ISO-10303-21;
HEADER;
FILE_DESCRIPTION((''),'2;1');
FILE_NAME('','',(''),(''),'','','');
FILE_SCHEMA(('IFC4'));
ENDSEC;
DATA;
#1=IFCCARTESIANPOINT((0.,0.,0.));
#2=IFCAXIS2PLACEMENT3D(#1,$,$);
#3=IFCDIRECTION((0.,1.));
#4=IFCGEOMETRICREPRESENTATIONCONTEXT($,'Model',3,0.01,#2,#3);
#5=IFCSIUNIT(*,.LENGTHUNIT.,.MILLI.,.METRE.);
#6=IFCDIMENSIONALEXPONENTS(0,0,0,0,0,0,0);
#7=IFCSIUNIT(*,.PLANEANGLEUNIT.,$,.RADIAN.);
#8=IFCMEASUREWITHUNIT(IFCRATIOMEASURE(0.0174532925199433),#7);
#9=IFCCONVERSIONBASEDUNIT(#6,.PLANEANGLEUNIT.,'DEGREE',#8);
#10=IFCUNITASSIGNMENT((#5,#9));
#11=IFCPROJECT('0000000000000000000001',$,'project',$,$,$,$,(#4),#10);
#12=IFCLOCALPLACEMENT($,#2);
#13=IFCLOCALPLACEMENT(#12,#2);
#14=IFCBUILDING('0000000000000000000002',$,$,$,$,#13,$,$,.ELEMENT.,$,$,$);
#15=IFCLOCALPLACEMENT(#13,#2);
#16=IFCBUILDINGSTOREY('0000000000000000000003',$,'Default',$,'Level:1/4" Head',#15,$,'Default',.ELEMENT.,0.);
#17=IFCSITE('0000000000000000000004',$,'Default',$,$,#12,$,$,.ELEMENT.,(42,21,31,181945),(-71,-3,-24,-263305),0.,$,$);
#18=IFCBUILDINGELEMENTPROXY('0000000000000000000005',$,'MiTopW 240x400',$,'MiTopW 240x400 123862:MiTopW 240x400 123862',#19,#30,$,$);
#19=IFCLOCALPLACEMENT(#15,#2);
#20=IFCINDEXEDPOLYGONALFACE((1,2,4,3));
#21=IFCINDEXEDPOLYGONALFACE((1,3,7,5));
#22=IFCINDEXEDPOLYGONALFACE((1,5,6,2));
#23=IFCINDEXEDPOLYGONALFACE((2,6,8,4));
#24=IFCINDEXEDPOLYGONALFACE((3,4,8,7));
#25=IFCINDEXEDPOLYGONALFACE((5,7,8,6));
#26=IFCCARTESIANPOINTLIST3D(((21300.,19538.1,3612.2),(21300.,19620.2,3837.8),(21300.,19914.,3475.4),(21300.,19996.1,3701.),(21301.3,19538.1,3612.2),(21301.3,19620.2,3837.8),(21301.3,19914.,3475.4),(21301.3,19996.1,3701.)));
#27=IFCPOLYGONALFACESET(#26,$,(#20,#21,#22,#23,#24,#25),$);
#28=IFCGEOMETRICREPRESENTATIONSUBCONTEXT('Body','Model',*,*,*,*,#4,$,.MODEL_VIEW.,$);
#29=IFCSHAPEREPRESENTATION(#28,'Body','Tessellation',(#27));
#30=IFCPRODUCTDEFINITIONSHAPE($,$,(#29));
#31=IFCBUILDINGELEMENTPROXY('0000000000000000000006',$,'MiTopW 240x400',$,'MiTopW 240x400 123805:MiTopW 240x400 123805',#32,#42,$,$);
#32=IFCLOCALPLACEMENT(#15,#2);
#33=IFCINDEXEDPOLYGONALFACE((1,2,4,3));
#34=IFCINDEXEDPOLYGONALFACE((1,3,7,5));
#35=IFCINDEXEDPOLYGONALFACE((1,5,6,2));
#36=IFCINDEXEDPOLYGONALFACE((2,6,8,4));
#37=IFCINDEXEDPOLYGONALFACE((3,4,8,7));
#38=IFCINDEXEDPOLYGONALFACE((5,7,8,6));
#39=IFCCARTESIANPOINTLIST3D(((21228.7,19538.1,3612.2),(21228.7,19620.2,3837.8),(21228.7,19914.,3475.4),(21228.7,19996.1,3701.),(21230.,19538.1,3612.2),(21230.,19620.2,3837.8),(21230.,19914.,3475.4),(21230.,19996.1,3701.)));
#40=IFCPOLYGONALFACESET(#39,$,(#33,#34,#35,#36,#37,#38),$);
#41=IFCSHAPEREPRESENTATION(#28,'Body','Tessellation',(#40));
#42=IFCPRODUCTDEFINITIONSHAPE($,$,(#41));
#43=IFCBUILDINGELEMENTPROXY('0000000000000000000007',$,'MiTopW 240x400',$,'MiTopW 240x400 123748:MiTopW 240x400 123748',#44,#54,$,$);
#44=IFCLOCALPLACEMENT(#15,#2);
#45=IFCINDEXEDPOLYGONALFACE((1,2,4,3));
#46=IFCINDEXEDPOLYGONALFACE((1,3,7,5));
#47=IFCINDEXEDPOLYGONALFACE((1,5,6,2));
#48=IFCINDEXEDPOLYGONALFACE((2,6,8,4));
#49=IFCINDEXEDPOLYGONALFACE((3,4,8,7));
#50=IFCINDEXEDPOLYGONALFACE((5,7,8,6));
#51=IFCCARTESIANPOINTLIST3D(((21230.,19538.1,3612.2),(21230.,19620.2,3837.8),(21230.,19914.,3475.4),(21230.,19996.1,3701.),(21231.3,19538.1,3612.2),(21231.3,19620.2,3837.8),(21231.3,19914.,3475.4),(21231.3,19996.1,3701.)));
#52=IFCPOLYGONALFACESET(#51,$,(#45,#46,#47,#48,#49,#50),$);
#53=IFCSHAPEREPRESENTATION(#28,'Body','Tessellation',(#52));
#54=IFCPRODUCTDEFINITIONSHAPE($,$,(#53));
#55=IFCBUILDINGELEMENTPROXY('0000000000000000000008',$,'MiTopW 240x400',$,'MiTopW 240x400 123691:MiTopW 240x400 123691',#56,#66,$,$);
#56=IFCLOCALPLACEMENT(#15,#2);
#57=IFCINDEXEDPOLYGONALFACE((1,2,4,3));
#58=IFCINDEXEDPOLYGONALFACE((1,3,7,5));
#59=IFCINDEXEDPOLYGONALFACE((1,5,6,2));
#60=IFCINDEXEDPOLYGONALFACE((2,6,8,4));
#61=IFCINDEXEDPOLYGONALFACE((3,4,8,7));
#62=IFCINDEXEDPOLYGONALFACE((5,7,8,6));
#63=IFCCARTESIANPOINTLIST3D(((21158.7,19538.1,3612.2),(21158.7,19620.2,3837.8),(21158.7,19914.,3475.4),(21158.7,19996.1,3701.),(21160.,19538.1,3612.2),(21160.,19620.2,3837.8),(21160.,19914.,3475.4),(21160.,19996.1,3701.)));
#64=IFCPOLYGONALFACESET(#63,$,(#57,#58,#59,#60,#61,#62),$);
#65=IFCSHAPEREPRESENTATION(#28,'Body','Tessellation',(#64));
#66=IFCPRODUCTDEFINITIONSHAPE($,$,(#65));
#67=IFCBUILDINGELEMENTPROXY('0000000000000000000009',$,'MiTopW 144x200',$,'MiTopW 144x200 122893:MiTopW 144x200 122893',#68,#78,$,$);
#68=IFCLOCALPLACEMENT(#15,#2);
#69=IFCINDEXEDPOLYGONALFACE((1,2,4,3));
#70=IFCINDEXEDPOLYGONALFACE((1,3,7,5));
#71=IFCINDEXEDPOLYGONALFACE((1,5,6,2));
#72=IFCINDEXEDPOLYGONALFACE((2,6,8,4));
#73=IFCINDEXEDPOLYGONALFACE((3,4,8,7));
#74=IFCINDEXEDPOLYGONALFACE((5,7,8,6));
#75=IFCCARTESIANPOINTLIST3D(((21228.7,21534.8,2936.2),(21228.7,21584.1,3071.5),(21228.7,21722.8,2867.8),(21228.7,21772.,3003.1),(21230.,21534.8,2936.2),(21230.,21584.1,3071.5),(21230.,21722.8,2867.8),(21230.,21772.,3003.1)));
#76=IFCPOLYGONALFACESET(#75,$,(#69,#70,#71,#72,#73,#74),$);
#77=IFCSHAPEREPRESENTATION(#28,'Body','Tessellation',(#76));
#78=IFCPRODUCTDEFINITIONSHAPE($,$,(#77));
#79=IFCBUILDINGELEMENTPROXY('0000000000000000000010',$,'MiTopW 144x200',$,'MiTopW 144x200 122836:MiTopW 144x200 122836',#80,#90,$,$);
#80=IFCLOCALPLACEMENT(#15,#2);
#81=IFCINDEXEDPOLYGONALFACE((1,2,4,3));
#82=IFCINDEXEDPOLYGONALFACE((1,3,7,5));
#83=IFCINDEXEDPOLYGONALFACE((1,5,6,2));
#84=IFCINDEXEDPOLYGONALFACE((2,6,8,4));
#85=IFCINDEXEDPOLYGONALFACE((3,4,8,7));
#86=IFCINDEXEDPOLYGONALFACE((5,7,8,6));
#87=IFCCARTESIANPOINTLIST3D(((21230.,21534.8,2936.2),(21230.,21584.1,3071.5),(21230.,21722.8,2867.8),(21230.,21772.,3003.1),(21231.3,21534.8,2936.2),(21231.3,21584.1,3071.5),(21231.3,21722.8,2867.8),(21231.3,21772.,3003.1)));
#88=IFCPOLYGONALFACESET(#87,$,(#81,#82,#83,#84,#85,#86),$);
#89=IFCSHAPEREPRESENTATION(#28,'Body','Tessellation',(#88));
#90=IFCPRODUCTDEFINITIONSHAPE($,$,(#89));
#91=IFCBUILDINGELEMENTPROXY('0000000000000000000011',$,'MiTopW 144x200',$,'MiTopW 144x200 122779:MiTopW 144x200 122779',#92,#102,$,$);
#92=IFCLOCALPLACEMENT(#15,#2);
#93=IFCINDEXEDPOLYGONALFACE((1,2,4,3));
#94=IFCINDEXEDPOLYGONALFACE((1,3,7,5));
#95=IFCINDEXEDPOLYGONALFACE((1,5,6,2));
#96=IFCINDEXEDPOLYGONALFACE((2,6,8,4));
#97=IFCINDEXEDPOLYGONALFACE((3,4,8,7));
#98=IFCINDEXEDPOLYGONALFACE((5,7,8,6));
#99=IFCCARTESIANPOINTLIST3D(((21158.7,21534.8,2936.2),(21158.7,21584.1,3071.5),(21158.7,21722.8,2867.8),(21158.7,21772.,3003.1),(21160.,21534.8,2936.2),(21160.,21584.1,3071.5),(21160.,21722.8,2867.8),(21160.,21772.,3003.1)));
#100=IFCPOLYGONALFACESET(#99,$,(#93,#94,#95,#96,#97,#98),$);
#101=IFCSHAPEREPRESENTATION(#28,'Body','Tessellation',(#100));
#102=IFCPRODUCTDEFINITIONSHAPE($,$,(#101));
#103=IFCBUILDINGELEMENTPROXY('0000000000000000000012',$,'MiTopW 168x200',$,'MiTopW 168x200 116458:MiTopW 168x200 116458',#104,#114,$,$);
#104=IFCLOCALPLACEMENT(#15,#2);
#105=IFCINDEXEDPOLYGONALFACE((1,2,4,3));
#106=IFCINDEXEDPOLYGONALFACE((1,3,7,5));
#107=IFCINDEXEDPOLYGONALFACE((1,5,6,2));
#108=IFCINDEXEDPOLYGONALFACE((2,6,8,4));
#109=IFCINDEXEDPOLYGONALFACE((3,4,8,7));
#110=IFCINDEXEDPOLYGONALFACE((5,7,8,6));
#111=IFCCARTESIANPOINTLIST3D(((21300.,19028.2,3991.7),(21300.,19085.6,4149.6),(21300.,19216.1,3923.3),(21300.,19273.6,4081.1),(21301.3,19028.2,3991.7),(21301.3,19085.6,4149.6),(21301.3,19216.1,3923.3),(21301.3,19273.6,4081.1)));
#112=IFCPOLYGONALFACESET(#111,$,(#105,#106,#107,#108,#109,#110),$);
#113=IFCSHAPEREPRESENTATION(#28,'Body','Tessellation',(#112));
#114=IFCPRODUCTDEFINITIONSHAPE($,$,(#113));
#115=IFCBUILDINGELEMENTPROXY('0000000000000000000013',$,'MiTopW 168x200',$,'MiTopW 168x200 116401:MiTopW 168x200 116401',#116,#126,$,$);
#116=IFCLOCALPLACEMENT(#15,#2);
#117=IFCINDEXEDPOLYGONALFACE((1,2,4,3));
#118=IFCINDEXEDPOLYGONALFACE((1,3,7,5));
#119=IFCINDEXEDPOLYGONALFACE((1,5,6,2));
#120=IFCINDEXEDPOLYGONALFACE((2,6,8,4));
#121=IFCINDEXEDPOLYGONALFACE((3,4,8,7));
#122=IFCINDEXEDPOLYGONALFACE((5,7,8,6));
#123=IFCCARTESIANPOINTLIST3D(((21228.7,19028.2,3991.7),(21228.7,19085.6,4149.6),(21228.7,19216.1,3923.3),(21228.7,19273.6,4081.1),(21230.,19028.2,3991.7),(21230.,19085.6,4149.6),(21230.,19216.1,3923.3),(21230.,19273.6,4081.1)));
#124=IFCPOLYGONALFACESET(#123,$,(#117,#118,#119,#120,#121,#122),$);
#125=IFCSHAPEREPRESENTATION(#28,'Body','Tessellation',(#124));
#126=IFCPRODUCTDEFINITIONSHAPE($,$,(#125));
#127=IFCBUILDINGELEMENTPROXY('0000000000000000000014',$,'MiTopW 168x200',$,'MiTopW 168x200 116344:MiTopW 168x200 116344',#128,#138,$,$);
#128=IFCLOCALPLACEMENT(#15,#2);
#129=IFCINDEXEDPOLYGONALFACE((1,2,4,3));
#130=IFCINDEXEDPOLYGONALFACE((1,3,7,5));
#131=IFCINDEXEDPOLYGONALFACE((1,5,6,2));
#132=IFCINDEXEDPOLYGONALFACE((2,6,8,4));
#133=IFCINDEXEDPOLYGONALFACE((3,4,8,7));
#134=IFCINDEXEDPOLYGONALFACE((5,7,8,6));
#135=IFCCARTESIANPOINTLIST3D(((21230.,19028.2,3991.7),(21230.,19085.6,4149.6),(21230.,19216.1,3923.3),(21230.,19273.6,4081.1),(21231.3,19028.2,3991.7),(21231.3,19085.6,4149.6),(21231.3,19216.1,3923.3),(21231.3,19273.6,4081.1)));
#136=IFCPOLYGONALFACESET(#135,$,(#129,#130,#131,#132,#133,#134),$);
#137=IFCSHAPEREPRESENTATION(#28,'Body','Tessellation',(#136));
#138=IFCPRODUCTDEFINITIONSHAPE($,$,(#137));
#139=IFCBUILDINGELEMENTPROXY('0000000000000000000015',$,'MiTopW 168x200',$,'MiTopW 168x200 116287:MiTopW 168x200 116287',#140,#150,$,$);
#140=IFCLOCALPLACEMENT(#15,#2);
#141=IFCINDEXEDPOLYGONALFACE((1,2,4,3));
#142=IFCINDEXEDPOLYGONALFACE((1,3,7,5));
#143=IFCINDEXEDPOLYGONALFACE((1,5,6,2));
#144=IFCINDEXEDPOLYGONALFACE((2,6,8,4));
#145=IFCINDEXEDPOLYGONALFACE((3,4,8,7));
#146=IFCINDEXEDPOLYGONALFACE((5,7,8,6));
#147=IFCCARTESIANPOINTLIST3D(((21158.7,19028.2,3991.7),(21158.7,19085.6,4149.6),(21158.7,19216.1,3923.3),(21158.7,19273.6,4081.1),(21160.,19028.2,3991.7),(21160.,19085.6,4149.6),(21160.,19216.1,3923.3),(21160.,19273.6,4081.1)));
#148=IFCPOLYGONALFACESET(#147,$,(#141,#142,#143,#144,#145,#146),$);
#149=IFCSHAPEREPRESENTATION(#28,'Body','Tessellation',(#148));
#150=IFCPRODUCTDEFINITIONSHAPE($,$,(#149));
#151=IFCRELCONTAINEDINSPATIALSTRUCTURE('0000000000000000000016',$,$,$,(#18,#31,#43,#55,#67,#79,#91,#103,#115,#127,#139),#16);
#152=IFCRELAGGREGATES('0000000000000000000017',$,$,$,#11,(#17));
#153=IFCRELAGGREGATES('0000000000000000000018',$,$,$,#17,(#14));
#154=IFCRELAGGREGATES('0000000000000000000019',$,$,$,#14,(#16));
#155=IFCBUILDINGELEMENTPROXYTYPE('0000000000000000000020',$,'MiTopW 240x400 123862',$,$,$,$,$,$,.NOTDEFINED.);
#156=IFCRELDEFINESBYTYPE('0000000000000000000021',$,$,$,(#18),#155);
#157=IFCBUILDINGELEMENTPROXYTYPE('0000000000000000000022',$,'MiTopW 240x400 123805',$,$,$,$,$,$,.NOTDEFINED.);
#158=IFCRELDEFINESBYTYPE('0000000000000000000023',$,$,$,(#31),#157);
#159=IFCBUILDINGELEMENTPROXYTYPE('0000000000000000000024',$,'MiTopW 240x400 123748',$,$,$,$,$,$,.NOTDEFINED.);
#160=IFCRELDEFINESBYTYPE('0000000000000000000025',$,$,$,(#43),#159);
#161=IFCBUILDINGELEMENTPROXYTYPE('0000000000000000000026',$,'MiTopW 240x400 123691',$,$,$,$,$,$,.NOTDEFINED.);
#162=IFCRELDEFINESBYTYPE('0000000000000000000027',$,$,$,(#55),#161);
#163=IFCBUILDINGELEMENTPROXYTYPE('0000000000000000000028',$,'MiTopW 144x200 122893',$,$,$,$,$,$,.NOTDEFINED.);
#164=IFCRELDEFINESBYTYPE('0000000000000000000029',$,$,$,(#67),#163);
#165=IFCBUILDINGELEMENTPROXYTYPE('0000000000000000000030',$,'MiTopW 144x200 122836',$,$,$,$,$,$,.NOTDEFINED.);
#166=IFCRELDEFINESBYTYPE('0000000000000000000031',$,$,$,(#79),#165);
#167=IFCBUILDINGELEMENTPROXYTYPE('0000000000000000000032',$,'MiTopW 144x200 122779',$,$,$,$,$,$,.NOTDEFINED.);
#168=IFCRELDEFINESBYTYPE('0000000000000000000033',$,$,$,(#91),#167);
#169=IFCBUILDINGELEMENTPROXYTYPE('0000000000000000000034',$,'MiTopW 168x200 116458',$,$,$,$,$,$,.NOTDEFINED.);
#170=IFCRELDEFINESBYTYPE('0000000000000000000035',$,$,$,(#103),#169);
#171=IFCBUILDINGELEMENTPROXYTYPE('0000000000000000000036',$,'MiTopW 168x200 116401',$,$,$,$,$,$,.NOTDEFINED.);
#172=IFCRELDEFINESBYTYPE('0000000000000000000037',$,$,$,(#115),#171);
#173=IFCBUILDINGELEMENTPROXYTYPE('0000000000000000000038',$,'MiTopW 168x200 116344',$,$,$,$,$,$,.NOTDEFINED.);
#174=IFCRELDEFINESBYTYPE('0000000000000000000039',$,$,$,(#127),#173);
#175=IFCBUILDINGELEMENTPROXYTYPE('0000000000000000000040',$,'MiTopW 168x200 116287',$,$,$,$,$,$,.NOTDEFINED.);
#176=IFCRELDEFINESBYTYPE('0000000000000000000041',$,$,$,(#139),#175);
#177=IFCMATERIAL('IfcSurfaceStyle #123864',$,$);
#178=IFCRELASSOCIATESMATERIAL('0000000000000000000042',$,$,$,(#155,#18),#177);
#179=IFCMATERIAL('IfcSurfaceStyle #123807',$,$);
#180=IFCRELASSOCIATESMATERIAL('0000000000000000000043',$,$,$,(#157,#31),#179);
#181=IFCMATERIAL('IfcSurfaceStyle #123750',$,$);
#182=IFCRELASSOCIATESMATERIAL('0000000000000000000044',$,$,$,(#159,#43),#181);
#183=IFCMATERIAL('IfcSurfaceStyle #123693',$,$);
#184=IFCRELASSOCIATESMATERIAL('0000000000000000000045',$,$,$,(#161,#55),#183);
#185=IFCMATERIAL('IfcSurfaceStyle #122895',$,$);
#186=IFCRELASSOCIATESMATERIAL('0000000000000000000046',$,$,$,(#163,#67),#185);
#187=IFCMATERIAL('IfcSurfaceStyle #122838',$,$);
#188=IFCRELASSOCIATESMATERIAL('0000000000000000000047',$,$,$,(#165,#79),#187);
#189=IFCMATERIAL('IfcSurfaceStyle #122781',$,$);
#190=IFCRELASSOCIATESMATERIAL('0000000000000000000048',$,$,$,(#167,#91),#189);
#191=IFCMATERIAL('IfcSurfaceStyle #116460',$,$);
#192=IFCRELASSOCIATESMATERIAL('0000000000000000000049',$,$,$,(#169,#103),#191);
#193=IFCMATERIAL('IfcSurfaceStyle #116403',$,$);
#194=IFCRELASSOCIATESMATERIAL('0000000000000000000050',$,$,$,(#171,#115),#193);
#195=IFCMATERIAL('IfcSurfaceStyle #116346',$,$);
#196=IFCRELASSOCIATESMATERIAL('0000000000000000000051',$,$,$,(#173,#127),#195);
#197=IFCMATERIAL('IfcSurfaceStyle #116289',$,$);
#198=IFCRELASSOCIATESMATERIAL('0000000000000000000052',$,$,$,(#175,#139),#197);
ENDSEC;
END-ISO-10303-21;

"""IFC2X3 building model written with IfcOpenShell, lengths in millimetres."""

from ifc_helpers import new_model, entity, si_unit, converted_unit, direction, frame, origin, place, context, subcontext, project, spatial, polyline, outline, extrude, source, transform, mapped, material, type_object, type_shapes, element, save


model = new_model("IFC2X3")

# Units and contexts
model_context = context("Model", 3, precision=0.01, world=origin(), true_north=direction((0.0, 1.0)))
body_context = subcontext(model_context, "Body", "Model", "MODEL_VIEW")
ifc_project = project(units=[si_unit("LENGTHUNIT", "METRE", prefix="MILLI"), converted_unit("PLANEANGLEUNIT", "DEGREE", entity("IfcRatioMeasure", 0.0174532925199433), si_unit("PLANEANGLEUNIT", "RADIAN"), dimensions=[0, 0, 0, 0, 0, 0, 0])], contexts=[model_context])

# Site, building, storey
site_placement = place(None, origin())
site = spatial("IfcSite", under=ifc_project, at=site_placement, Name="Default", CompositionType="ELEMENT", RefLatitude=(42, 21, 31, 181945), RefLongitude=(-71, -3, -24, -263305), RefElevation=0.0)
building_placement = place(site_placement, origin())
building = spatial("IfcBuilding", under=site, at=building_placement, CompositionType="ELEMENT")
storey_placement = place(building_placement, origin())
storey = spatial("IfcBuildingStorey", under=building, at=storey_placement, Name="Default", ObjectType="Level:1/4\" Head", LongName="Default", CompositionType="ELEMENT", Elevation=0.0)

# Building element proxies
ifc_material_1 = material(Name="IfcSurfaceStyle #123864")
building_element_proxy_type_1 = type_object("IfcBuildingElementProxyType", Name="MiTopW 240x400 123862", PredefinedType="NOTDEFINED", material=ifc_material_1)
shared_shape_1 = source(origin(), body_context, "Body", "SweptSolid", [
    extrude(outline(polyline([(-200.0, -120.0), (200.0, -120.0), (200.0, 120.0), (-200.0, 120.0), (-200.0, -120.0)])), frame((200.0, 120.0, 0.0), z_axis=(0.0, 0.0, 1.0), x_axis=(-1.0, 0.0, 0.0)), (0.0, 0.0, 1.0), 1.3),
])
type_shapes(building_element_proxy_type_1, [shared_shape_1])
proxy_1_placement = place(building_placement, frame((21301.3, 19620.2, 3837.8), z_axis=(-1.0, 0.0, 0.0), x_axis=(0.0, 0.939693, -0.34202)))
element("IfcBuildingElementProxy", 1, at=proxy_1_placement, inside=storey, type_object=building_element_proxy_type_1, material=ifc_material_1, Name="MiTopW 240x400", ObjectType="MiTopW 240x400 123862:MiTopW 240x400 123862", context=body_context, shape_type="MappedRepresentation", body=[
    mapped(shared_shape_1, transform((0.0, 0.0, 0.0), scale=1.0)),
])
ifc_material_2 = material(Name="IfcSurfaceStyle #123807")
building_element_proxy_type_2 = type_object("IfcBuildingElementProxyType", Name="MiTopW 240x400 123805", PredefinedType="NOTDEFINED", material=ifc_material_2)
shared_shape_2 = source(origin(), body_context, "Body", "SweptSolid", [
    extrude(outline(polyline([(-200.0, -120.0), (200.0, -120.0), (200.0, 120.0), (-200.0, 120.0), (-200.0, -120.0)])), frame((200.0, 120.0, 0.0), z_axis=(0.0, 0.0, 1.0), x_axis=(-1.0, 0.0, 0.0)), (0.0, 0.0, 1.0), 1.3),
])
type_shapes(building_element_proxy_type_2, [shared_shape_2])
proxy_2_placement = place(building_placement, frame((21230.0, 19620.2, 3837.8), z_axis=(-1.0, 0.0, 0.0), x_axis=(0.0, 0.939693, -0.34202)))
element("IfcBuildingElementProxy", 2, at=proxy_2_placement, inside=storey, type_object=building_element_proxy_type_2, material=ifc_material_2, Name="MiTopW 240x400", ObjectType="MiTopW 240x400 123805:MiTopW 240x400 123805", context=body_context, shape_type="MappedRepresentation", body=[
    mapped(shared_shape_2, transform((0.0, 0.0, 0.0), scale=1.0)),
])
ifc_material_3 = material(Name="IfcSurfaceStyle #123750")
building_element_proxy_type_3 = type_object("IfcBuildingElementProxyType", Name="MiTopW 240x400 123748", PredefinedType="NOTDEFINED", material=ifc_material_3)
shared_shape_3 = source(origin(), body_context, "Body", "SweptSolid", [
    extrude(outline(polyline([(-200.0, -120.0), (200.0, -120.0), (200.0, 120.0), (-200.0, 120.0), (-200.0, -120.0)])), frame((200.0, 120.0, 0.0), z_axis=(0.0, 0.0, 1.0), x_axis=(-1.0, 0.0, 0.0)), (0.0, 0.0, 1.0), 1.3),
])
type_shapes(building_element_proxy_type_3, [shared_shape_3])
proxy_3_placement = place(building_placement, frame((21231.3, 19620.2, 3837.8), z_axis=(-1.0, 0.0, 0.0), x_axis=(0.0, 0.939693, -0.34202)))
element("IfcBuildingElementProxy", 3, at=proxy_3_placement, inside=storey, type_object=building_element_proxy_type_3, material=ifc_material_3, Name="MiTopW 240x400", ObjectType="MiTopW 240x400 123748:MiTopW 240x400 123748", context=body_context, shape_type="MappedRepresentation", body=[
    mapped(shared_shape_3, transform((0.0, 0.0, 0.0), scale=1.0)),
])
ifc_material_4 = material(Name="IfcSurfaceStyle #123693")
building_element_proxy_type_4 = type_object("IfcBuildingElementProxyType", Name="MiTopW 240x400 123691", PredefinedType="NOTDEFINED", material=ifc_material_4)
shared_shape_4 = source(origin(), body_context, "Body", "SweptSolid", [
    extrude(outline(polyline([(-200.0, -120.0), (200.0, -120.0), (200.0, 120.0), (-200.0, 120.0), (-200.0, -120.0)])), frame((200.0, 120.0, 0.0), z_axis=(0.0, 0.0, 1.0), x_axis=(-1.0, 0.0, 0.0)), (0.0, 0.0, 1.0), 1.3),
])
type_shapes(building_element_proxy_type_4, [shared_shape_4])
proxy_4_placement = place(building_placement, frame((21160.0, 19620.2, 3837.8), z_axis=(-1.0, 0.0, 0.0), x_axis=(0.0, 0.939693, -0.34202)))
element("IfcBuildingElementProxy", 4, at=proxy_4_placement, inside=storey, type_object=building_element_proxy_type_4, material=ifc_material_4, Name="MiTopW 240x400", ObjectType="MiTopW 240x400 123691:MiTopW 240x400 123691", context=body_context, shape_type="MappedRepresentation", body=[
    mapped(shared_shape_4, transform((0.0, 0.0, 0.0), scale=1.0)),
])
ifc_material_5 = material(Name="IfcSurfaceStyle #122895")
building_element_proxy_type_5 = type_object("IfcBuildingElementProxyType", Name="MiTopW 144x200 122893", PredefinedType="NOTDEFINED", material=ifc_material_5)
shared_shape_5 = source(origin(), body_context, "Body", "SweptSolid", [
    extrude(outline(polyline([(-100.0, -72.0), (100.0, -72.0), (100.0, 72.0), (-100.0, 72.0), (-100.0, -72.0)])), frame((100.0, 72.0, 0.0), z_axis=(0.0, 0.0, 1.0), x_axis=(-1.0, 0.0, 0.0)), (0.0, 0.0, 1.0), 1.3),
])
type_shapes(building_element_proxy_type_5, [shared_shape_5])
proxy_5_placement = place(building_placement, frame((21230.0, 21584.1, 3071.5), z_axis=(-1.0, 0.0, 0.0), x_axis=(0.0, 0.939693, -0.34202)))
element("IfcBuildingElementProxy", 5, at=proxy_5_placement, inside=storey, type_object=building_element_proxy_type_5, material=ifc_material_5, Name="MiTopW 144x200", ObjectType="MiTopW 144x200 122893:MiTopW 144x200 122893", context=body_context, shape_type="MappedRepresentation", body=[
    mapped(shared_shape_5, transform((0.0, 0.0, 0.0), scale=1.0)),
])
ifc_material_6 = material(Name="IfcSurfaceStyle #122838")
building_element_proxy_type_6 = type_object("IfcBuildingElementProxyType", Name="MiTopW 144x200 122836", PredefinedType="NOTDEFINED", material=ifc_material_6)
shared_shape_6 = source(origin(), body_context, "Body", "SweptSolid", [
    extrude(outline(polyline([(-100.0, -72.0), (100.0, -72.0), (100.0, 72.0), (-100.0, 72.0), (-100.0, -72.0)])), frame((100.0, 72.0, 0.0), z_axis=(0.0, 0.0, 1.0), x_axis=(-1.0, 0.0, 0.0)), (0.0, 0.0, 1.0), 1.3),
])
type_shapes(building_element_proxy_type_6, [shared_shape_6])
proxy_6_placement = place(building_placement, frame((21231.3, 21584.1, 3071.5), z_axis=(-1.0, 0.0, 0.0), x_axis=(0.0, 0.939693, -0.34202)))
element("IfcBuildingElementProxy", 6, at=proxy_6_placement, inside=storey, type_object=building_element_proxy_type_6, material=ifc_material_6, Name="MiTopW 144x200", ObjectType="MiTopW 144x200 122836:MiTopW 144x200 122836", context=body_context, shape_type="MappedRepresentation", body=[
    mapped(shared_shape_6, transform((0.0, 0.0, 0.0), scale=1.0)),
])
ifc_material_7 = material(Name="IfcSurfaceStyle #122781")
building_element_proxy_type_7 = type_object("IfcBuildingElementProxyType", Name="MiTopW 144x200 122779", PredefinedType="NOTDEFINED", material=ifc_material_7)
shared_shape_7 = source(origin(), body_context, "Body", "SweptSolid", [
    extrude(outline(polyline([(-100.0, -72.0), (100.0, -72.0), (100.0, 72.0), (-100.0, 72.0), (-100.0, -72.0)])), frame((100.0, 72.0, 0.0), z_axis=(0.0, 0.0, 1.0), x_axis=(-1.0, 0.0, 0.0)), (0.0, 0.0, 1.0), 1.3),
])
type_shapes(building_element_proxy_type_7, [shared_shape_7])
proxy_7_placement = place(building_placement, frame((21160.0, 21584.1, 3071.5), z_axis=(-1.0, 0.0, 0.0), x_axis=(0.0, 0.939693, -0.34202)))
element("IfcBuildingElementProxy", 7, at=proxy_7_placement, inside=storey, type_object=building_element_proxy_type_7, material=ifc_material_7, Name="MiTopW 144x200", ObjectType="MiTopW 144x200 122779:MiTopW 144x200 122779", context=body_context, shape_type="MappedRepresentation", body=[
    mapped(shared_shape_7, transform((0.0, 0.0, 0.0), scale=1.0)),
])
ifc_material_8 = material(Name="IfcSurfaceStyle #116460")
building_element_proxy_type_8 = type_object("IfcBuildingElementProxyType", Name="MiTopW 168x200 116458", PredefinedType="NOTDEFINED", material=ifc_material_8)
shared_shape_8 = source(origin(), body_context, "Body", "SweptSolid", [
    extrude(outline(polyline([(-100.0, -84.0), (100.0, -84.0), (100.0, 84.0), (-100.0, 84.0), (-100.0, -84.0)])), frame((100.0, 84.0, 0.0), z_axis=(0.0, 0.0, 1.0), x_axis=(-1.0, 0.0, 0.0)), (0.0, 0.0, 1.0), 1.3),
])
type_shapes(building_element_proxy_type_8, [shared_shape_8])
proxy_8_placement = place(building_placement, frame((21301.3, 19216.1, 3923.3), z_axis=(-1.0, 0.0, 0.0), x_axis=(0.0, -0.939693, 0.34202)))
element("IfcBuildingElementProxy", 8, at=proxy_8_placement, inside=storey, type_object=building_element_proxy_type_8, material=ifc_material_8, Name="MiTopW 168x200", ObjectType="MiTopW 168x200 116458:MiTopW 168x200 116458", context=body_context, shape_type="MappedRepresentation", body=[
    mapped(shared_shape_8, transform((0.0, 0.0, 0.0), scale=1.0)),
])
ifc_material_9 = material(Name="IfcSurfaceStyle #116403")
building_element_proxy_type_9 = type_object("IfcBuildingElementProxyType", Name="MiTopW 168x200 116401", PredefinedType="NOTDEFINED", material=ifc_material_9)
shared_shape_9 = source(origin(), body_context, "Body", "SweptSolid", [
    extrude(outline(polyline([(-100.0, -84.0), (100.0, -84.0), (100.0, 84.0), (-100.0, 84.0), (-100.0, -84.0)])), frame((100.0, 84.0, 0.0), z_axis=(0.0, 0.0, 1.0), x_axis=(-1.0, 0.0, 0.0)), (0.0, 0.0, 1.0), 1.3),
])
type_shapes(building_element_proxy_type_9, [shared_shape_9])
proxy_9_placement = place(building_placement, frame((21230.0, 19216.1, 3923.3), z_axis=(-1.0, 0.0, 0.0), x_axis=(0.0, -0.939693, 0.34202)))
element("IfcBuildingElementProxy", 9, at=proxy_9_placement, inside=storey, type_object=building_element_proxy_type_9, material=ifc_material_9, Name="MiTopW 168x200", ObjectType="MiTopW 168x200 116401:MiTopW 168x200 116401", context=body_context, shape_type="MappedRepresentation", body=[
    mapped(shared_shape_9, transform((0.0, 0.0, 0.0), scale=1.0)),
])
ifc_material_10 = material(Name="IfcSurfaceStyle #116346")
building_element_proxy_type_10 = type_object("IfcBuildingElementProxyType", Name="MiTopW 168x200 116344", PredefinedType="NOTDEFINED", material=ifc_material_10)
shared_shape_10 = source(origin(), body_context, "Body", "SweptSolid", [
    extrude(outline(polyline([(-100.0, -84.0), (100.0, -84.0), (100.0, 84.0), (-100.0, 84.0), (-100.0, -84.0)])), frame((100.0, 84.0, 0.0), z_axis=(0.0, 0.0, 1.0), x_axis=(-1.0, 0.0, 0.0)), (0.0, 0.0, 1.0), 1.3),
])
type_shapes(building_element_proxy_type_10, [shared_shape_10])
proxy_10_placement = place(building_placement, frame((21231.3, 19216.1, 3923.3), z_axis=(-1.0, 0.0, 0.0), x_axis=(0.0, -0.939693, 0.34202)))
element("IfcBuildingElementProxy", 10, at=proxy_10_placement, inside=storey, type_object=building_element_proxy_type_10, material=ifc_material_10, Name="MiTopW 168x200", ObjectType="MiTopW 168x200 116344:MiTopW 168x200 116344", context=body_context, shape_type="MappedRepresentation", body=[
    mapped(shared_shape_10, transform((0.0, 0.0, 0.0), scale=1.0)),
])
ifc_material_11 = material(Name="IfcSurfaceStyle #116289")
building_element_proxy_type_11 = type_object("IfcBuildingElementProxyType", Name="MiTopW 168x200 116287", PredefinedType="NOTDEFINED", material=ifc_material_11)
shared_shape_11 = source(origin(), body_context, "Body", "SweptSolid", [
    extrude(outline(polyline([(-100.0, -84.0), (100.0, -84.0), (100.0, 84.0), (-100.0, 84.0), (-100.0, -84.0)])), frame((100.0, 84.0, 0.0), z_axis=(0.0, 0.0, 1.0), x_axis=(-1.0, 0.0, 0.0)), (0.0, 0.0, 1.0), 1.3),
])
type_shapes(building_element_proxy_type_11, [shared_shape_11])
proxy_11_placement = place(building_placement, frame((21160.0, 19216.1, 3923.3), z_axis=(-1.0, 0.0, 0.0), x_axis=(0.0, -0.939693, 0.34202)))
element("IfcBuildingElementProxy", 11, at=proxy_11_placement, inside=storey, type_object=building_element_proxy_type_11, material=ifc_material_11, Name="MiTopW 168x200", ObjectType="MiTopW 168x200 116287:MiTopW 168x200 116287", context=body_context, shape_type="MappedRepresentation", body=[
    mapped(shared_shape_11, transform((0.0, 0.0, 0.0), scale=1.0)),
])

save(model, "model.ifc")
